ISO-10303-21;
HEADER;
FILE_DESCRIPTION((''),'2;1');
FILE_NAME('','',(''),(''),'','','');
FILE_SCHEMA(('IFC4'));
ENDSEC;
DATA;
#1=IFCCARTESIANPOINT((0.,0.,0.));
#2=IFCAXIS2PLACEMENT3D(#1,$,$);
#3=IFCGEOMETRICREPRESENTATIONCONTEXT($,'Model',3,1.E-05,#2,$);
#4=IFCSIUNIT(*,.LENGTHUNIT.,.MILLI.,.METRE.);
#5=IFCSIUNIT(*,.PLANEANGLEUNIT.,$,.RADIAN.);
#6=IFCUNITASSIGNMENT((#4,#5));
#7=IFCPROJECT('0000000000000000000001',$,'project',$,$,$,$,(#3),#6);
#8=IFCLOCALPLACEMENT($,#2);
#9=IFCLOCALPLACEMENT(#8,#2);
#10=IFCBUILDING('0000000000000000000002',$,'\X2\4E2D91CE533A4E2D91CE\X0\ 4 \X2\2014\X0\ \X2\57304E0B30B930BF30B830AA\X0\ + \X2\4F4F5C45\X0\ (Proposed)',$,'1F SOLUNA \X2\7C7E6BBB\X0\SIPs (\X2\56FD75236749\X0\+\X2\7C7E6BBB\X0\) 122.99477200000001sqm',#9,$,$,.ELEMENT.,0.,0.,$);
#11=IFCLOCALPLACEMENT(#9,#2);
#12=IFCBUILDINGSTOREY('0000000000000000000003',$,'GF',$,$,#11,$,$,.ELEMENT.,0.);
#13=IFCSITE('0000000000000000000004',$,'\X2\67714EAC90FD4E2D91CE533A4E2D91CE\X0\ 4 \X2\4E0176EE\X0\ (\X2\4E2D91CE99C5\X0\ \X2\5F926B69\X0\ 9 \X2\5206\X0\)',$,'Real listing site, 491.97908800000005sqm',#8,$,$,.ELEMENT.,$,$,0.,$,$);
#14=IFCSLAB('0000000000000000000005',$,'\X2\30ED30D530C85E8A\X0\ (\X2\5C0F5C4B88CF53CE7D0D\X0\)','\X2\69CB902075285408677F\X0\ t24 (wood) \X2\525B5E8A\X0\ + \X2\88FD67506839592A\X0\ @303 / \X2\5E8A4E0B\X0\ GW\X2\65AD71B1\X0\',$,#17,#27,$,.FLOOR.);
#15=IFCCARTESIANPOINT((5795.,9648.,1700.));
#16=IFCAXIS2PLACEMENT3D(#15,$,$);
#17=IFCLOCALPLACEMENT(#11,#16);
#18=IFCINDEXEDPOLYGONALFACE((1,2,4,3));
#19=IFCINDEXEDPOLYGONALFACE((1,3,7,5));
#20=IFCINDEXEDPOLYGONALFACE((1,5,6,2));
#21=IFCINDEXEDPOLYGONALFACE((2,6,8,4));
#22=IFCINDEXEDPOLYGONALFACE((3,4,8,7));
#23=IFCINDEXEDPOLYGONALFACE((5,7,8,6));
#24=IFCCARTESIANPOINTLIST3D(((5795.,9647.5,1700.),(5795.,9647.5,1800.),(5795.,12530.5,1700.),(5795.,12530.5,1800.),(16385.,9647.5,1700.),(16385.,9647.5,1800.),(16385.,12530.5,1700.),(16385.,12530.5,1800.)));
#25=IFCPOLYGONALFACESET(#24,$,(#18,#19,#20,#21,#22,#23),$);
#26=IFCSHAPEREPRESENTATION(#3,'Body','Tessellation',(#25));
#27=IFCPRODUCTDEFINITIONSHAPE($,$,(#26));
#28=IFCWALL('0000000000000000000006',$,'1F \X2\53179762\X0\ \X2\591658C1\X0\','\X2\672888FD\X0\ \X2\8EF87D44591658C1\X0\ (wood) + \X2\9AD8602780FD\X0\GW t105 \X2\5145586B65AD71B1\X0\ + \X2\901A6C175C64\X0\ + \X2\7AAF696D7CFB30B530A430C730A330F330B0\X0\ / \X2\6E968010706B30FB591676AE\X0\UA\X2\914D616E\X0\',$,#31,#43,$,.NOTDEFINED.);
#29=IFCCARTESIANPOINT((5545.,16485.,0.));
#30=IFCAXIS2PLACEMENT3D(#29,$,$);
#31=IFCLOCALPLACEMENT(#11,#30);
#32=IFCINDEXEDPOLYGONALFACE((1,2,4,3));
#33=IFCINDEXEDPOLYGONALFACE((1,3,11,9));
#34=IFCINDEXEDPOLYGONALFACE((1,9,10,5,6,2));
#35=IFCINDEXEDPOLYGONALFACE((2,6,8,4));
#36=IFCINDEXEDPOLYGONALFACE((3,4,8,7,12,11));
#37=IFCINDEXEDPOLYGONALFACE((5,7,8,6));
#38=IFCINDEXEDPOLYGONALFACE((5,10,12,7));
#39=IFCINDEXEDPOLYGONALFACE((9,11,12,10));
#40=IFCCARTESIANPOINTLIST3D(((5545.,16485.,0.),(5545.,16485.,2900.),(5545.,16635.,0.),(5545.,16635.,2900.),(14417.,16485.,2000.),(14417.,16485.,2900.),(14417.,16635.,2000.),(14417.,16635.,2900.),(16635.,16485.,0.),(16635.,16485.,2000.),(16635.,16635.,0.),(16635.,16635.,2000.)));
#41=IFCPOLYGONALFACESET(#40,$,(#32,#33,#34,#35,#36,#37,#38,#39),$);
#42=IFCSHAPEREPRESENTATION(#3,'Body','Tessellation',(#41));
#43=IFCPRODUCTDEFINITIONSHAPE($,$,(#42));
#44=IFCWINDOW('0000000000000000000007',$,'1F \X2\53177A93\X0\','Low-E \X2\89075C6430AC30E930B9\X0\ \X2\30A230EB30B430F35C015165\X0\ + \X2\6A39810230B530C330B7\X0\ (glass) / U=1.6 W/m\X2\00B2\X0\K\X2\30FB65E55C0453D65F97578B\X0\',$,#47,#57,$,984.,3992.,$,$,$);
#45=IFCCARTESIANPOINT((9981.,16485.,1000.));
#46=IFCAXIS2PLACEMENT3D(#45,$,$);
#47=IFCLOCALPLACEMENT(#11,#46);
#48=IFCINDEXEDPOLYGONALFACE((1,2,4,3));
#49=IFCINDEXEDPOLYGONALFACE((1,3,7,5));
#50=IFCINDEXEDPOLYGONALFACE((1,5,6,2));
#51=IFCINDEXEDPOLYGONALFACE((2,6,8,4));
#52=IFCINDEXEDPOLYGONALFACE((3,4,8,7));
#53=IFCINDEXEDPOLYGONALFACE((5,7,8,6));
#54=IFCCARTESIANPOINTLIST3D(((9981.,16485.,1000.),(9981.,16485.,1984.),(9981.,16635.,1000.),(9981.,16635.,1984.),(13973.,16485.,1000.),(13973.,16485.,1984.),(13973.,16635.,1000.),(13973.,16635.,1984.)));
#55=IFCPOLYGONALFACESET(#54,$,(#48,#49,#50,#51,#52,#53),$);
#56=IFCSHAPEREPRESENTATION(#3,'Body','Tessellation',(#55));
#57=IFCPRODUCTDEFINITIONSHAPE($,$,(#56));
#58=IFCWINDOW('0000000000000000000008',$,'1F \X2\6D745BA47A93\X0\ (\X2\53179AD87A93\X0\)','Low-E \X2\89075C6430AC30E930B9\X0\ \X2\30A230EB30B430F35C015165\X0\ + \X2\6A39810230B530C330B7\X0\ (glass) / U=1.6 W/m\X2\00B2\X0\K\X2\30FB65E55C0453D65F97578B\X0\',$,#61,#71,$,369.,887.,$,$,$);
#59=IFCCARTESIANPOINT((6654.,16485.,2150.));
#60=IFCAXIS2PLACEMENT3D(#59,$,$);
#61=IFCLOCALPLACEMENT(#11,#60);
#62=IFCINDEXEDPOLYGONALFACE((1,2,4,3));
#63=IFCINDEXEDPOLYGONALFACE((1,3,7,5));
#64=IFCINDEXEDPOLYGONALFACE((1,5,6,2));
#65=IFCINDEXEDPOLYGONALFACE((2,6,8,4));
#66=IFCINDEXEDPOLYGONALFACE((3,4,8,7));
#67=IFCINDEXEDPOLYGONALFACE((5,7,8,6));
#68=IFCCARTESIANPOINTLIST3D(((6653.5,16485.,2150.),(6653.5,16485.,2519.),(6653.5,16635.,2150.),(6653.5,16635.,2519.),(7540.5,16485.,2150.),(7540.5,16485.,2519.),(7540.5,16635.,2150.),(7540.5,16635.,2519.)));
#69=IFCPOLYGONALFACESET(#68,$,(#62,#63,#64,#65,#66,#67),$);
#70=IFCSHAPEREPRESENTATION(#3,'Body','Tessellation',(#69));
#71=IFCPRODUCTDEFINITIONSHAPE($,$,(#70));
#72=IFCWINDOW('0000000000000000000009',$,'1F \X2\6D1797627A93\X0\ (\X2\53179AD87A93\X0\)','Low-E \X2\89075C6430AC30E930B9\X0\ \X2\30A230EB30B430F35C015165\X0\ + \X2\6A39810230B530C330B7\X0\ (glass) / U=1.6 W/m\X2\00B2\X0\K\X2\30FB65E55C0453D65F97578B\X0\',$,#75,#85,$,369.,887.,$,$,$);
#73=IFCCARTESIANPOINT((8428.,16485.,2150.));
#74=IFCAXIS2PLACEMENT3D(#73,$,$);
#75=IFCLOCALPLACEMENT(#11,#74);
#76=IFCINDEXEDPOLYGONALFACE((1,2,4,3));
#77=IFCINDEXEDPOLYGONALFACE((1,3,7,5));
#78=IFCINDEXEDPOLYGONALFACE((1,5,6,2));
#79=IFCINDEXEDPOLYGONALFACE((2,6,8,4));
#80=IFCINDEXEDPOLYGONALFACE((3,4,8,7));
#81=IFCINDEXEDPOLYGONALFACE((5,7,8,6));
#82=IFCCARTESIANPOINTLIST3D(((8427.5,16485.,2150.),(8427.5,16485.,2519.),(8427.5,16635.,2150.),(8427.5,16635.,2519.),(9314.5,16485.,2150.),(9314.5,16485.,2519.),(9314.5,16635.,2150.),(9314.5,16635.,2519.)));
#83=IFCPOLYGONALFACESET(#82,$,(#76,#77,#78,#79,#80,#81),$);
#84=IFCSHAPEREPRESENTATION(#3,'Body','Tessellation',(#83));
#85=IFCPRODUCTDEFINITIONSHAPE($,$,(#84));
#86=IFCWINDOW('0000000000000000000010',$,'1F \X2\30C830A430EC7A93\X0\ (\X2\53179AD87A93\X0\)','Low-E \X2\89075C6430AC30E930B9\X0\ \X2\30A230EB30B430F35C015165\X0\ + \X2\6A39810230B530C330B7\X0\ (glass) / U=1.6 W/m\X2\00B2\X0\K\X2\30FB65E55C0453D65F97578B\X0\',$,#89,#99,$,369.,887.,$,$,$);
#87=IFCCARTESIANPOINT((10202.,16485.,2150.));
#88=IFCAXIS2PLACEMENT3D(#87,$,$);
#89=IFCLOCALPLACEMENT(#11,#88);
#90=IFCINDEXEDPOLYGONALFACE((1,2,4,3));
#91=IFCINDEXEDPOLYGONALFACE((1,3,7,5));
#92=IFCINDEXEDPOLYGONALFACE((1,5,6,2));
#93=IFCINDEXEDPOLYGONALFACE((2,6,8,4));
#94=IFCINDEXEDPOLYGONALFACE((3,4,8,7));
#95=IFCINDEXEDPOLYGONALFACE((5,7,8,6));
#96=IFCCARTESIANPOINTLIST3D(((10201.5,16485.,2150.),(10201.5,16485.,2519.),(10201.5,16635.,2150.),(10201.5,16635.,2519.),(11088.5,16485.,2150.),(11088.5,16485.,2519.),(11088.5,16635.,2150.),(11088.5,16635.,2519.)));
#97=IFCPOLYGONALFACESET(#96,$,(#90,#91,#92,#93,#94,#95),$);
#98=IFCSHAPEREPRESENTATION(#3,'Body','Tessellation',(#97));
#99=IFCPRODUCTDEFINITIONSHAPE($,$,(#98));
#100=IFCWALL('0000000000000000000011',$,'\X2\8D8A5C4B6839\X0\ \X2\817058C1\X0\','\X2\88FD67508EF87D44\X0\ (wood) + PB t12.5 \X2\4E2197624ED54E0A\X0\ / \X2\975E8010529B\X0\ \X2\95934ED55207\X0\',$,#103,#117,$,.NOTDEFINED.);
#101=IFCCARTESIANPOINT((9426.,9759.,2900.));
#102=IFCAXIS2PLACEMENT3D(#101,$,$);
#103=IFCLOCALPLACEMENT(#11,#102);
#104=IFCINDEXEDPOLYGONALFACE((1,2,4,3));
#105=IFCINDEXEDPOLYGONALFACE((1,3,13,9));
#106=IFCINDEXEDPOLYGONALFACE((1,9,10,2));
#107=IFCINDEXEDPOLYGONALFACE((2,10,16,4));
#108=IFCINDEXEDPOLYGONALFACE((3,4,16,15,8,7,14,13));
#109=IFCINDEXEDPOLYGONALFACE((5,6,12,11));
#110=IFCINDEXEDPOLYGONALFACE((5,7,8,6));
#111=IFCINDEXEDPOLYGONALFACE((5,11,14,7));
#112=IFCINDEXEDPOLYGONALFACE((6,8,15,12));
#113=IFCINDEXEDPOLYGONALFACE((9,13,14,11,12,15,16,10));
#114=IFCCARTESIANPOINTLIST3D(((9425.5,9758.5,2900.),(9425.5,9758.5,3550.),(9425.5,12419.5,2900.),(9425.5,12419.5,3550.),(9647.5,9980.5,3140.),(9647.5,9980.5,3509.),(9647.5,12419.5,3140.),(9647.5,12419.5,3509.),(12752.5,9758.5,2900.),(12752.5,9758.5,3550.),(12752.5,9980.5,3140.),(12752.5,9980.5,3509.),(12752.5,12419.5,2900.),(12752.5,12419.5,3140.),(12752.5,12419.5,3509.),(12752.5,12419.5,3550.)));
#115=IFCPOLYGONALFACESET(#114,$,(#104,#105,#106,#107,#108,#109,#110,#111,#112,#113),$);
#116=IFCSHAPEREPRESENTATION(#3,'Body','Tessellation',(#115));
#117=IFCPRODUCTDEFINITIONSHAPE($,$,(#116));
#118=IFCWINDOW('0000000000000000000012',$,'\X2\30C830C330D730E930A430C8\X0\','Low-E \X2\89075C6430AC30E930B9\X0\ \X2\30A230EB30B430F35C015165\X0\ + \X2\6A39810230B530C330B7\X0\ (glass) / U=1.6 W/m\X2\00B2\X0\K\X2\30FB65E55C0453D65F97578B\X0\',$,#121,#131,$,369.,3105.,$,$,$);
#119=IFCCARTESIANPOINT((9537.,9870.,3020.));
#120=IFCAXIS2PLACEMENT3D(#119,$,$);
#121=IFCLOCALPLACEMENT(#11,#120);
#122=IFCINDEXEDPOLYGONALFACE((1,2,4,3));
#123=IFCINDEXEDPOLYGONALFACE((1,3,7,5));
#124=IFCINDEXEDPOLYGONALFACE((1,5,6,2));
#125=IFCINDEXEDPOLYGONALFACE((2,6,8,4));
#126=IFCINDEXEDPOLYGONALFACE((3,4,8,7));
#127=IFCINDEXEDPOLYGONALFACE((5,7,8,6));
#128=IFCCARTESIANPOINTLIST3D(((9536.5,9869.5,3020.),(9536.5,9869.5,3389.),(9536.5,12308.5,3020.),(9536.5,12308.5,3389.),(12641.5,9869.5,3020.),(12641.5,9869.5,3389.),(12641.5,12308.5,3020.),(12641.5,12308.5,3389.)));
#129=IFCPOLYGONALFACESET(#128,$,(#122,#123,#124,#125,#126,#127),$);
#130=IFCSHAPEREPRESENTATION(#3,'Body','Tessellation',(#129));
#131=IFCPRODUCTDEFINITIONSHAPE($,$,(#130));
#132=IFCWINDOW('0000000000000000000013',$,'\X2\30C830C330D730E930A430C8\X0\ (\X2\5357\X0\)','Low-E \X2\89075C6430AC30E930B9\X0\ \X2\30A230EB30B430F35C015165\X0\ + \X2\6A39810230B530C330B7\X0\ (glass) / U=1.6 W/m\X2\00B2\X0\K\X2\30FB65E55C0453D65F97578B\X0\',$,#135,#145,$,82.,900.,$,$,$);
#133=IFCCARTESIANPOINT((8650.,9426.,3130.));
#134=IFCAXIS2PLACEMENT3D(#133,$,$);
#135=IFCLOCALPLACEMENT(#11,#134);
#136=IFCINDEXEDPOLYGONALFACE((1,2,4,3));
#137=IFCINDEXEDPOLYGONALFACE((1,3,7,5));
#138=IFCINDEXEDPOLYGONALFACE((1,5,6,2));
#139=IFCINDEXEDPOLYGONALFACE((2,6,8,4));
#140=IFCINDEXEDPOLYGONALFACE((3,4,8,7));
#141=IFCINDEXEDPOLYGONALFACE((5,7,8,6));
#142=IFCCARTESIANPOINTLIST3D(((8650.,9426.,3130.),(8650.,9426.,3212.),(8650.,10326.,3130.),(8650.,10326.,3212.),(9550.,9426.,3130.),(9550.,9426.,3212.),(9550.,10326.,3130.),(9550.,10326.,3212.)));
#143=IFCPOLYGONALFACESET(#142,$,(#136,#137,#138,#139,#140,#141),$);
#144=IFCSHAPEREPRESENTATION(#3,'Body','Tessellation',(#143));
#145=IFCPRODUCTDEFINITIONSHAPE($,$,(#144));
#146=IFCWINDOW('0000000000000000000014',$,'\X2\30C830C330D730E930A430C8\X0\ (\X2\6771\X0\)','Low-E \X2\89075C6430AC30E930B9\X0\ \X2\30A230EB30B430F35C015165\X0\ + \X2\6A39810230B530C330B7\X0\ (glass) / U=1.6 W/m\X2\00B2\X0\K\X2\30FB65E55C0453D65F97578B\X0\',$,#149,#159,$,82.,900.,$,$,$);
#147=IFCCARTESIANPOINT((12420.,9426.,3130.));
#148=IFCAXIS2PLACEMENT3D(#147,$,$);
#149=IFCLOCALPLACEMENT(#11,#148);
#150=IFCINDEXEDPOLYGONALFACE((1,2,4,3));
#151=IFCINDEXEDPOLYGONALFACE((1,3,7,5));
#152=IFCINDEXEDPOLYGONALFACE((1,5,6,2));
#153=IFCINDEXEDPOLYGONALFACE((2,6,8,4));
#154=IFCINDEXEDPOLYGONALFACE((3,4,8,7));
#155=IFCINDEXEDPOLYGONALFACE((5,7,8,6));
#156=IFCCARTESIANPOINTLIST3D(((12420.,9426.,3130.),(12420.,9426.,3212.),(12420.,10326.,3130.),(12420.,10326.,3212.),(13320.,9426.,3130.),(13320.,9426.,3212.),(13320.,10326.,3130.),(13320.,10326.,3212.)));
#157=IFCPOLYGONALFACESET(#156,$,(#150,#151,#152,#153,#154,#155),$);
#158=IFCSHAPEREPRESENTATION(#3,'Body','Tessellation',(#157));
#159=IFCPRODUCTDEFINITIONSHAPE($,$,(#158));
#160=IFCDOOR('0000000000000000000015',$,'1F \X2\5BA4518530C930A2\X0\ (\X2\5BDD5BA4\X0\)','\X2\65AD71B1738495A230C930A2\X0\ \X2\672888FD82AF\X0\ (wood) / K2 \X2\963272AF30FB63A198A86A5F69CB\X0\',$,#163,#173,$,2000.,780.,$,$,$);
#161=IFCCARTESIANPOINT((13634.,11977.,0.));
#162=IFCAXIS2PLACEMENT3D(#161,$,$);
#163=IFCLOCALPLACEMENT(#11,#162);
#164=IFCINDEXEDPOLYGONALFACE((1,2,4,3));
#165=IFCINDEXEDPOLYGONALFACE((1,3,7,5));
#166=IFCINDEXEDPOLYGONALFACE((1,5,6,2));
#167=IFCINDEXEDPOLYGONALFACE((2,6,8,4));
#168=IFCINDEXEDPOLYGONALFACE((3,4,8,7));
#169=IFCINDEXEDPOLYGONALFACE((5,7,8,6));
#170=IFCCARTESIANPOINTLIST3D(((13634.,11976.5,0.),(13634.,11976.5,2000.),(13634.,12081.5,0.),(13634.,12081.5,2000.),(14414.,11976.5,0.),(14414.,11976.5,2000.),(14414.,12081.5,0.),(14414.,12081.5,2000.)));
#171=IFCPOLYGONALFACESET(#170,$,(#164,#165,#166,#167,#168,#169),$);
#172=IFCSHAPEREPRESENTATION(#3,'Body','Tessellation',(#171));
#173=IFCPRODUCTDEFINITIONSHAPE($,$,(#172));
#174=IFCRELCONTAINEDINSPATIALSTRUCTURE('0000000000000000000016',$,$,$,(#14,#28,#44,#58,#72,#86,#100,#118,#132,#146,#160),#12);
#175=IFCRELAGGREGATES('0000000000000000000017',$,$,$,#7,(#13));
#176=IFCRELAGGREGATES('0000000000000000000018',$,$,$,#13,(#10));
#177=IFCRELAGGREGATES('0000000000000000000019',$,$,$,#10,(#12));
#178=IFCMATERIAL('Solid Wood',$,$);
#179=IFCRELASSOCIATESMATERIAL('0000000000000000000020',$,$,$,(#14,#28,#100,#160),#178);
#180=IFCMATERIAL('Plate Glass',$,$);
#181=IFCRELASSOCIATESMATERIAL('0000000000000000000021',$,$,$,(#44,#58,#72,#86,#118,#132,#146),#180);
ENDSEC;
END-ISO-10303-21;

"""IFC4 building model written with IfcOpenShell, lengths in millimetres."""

from ifc_helpers import new_model, si_unit, frame, frame_2d, origin, place, context, project, spatial, rectangle, extrude, material, element, fill, save


model = new_model("IFC4")

# Units and contexts
model_context = context("Model", 3, precision=1e-05, world=origin())
ifc_project = project(units=[si_unit("LENGTHUNIT", "METRE", prefix="MILLI"), si_unit("PLANEANGLEUNIT", "RADIAN")], contexts=[model_context])

# Site, building, storey
site_placement = place(None, origin())
site = spatial("IfcSite", under=ifc_project, at=site_placement, Name="東京都中野区中野 4 丁目 (中野駅 徒歩 9 分)", ObjectType="Real listing site, 491.97908800000005sqm", CompositionType="ELEMENT", RefElevation=0.0)
building_placement = place(site_placement, origin())
building = spatial("IfcBuilding", under=site, at=building_placement, Name="中野区中野 4 — 地下スタジオ + 住居 (Proposed)", ObjectType="1F SOLUNA 籾殻SIPs (国産杉+籾殻) 122.99477200000001sqm", CompositionType="ELEMENT", ElevationOfRefHeight=0.0, ElevationOfTerrain=0.0)
storey_placement = place(building_placement, origin())
storey = spatial("IfcBuildingStorey", under=building, at=storey_placement, Name="GF", CompositionType="ELEMENT", Elevation=0.0)

# Slab
ifc_material_1 = material(Name="Solid Wood")
slab_placement = place(storey_placement, frame((5795.0, 9648.0, 1700.0)))
element("IfcSlab", 1, at=slab_placement, inside=storey, material=ifc_material_1, Name="ロフト床 (小屋裏収納)", Description="構造用合板 t24 (wood) 剛床 + 製材根太 @303 / 床下 GW断熱", PredefinedType="FLOOR", context=model_context, shape_type="SweptSolid", body=[
    extrude(rectangle(XDim=10590.0, YDim=2883.0, at=frame_2d((5295.0, 1441.0))), frame((5795.0, 9648.0, 1700.0)), (0.0, 0.0, 1.0), 100.0),
])

# Wall, openings, windows
wall_1_placement = place(storey_placement, frame((5545.0, 16485.0, 0.0)))
wall_1 = element("IfcWall", 2, at=wall_1_placement, inside=storey, material=ifc_material_1, Name="1F 北面 外壁", Description="木製 軸組外壁 (wood) + 高性能GW t105 充填断熱 + 通気層 + 窯業系サイディング / 準耐火・外皮UA配慮", PredefinedType="NOTDEFINED", context=model_context, shape_type="SweptSolid", body=[
    extrude(rectangle(XDim=11090.0, YDim=150.0, at=frame_2d((5545.0, 75.0))), frame((5545.0, 16485.0, 0.0)), (0.0, 0.0, 1.0), 2900.0),
])
opening_1_placement = place(storey_placement, frame((9981.0, 16485.0, 1000.0)))
opening_1 = element("IfcOpeningElement", 3, at=opening_1_placement, cuts=wall_1, PredefinedType="NOTDEFINED", context=model_context, shape_type="SweptSolid", body=[
    extrude(rectangle(XDim=3992.0, YDim=150.0, at=frame_2d((1996.0, 75.0))), frame((9981.0, 16485.0, 1000.0)), (0.0, 0.0, 1.0), 984.0),
])
opening_2_placement = place(storey_placement, frame((6654.0, 16485.0, 2150.0)))
opening_2 = element("IfcOpeningElement", 4, at=opening_2_placement, cuts=wall_1, PredefinedType="NOTDEFINED", context=model_context, shape_type="SweptSolid", body=[
    extrude(rectangle(XDim=887.0, YDim=150.0, at=frame_2d((443.0, 75.0))), frame((6654.0, 16485.0, 2150.0)), (0.0, 0.0, 1.0), 369.0),
])
opening_3_placement = place(storey_placement, frame((8428.0, 16485.0, 2150.0)))
opening_3 = element("IfcOpeningElement", 5, at=opening_3_placement, cuts=wall_1, PredefinedType="NOTDEFINED", context=model_context, shape_type="SweptSolid", body=[
    extrude(rectangle(XDim=887.0, YDim=150.0, at=frame_2d((443.0, 75.0))), frame((8428.0, 16485.0, 2150.0)), (0.0, 0.0, 1.0), 369.0),
])
opening_4_placement = place(storey_placement, frame((10202.0, 16485.0, 2150.0)))
opening_4 = element("IfcOpeningElement", 6, at=opening_4_placement, cuts=wall_1, PredefinedType="NOTDEFINED", context=model_context, shape_type="SweptSolid", body=[
    extrude(rectangle(XDim=887.0, YDim=150.0, at=frame_2d((443.0, 75.0))), frame((10202.0, 16485.0, 2150.0)), (0.0, 0.0, 1.0), 369.0),
])
ifc_material_2 = material(Name="Plate Glass")
window_1_placement = place(storey_placement, frame((9981.0, 16485.0, 1000.0)))
window_1 = element("IfcWindow", 7, at=window_1_placement, inside=storey, material=ifc_material_2, Name="1F 北窓", Description="Low-E 複層ガラス アルゴン封入 + 樹脂サッシ (glass) / U=1.6 W/m²K・日射取得型", OverallHeight=984.0, OverallWidth=3992.0, context=model_context, shape_type="SweptSolid", body=[
    extrude(rectangle(XDim=3992.0, YDim=150.0, at=frame_2d((1996.0, 75.0))), frame((9981.0, 16485.0, 1000.0)), (0.0, 0.0, 1.0), 984.0),
])
fill(opening_1, window_1)
window_2_placement = place(storey_placement, frame((6654.0, 16485.0, 2150.0)))
window_2 = element("IfcWindow", 8, at=window_2_placement, inside=storey, material=ifc_material_2, Name="1F 浴室窓 (北高窓)", Description="Low-E 複層ガラス アルゴン封入 + 樹脂サッシ (glass) / U=1.6 W/m²K・日射取得型", OverallHeight=369.0, OverallWidth=887.0, context=model_context, shape_type="SweptSolid", body=[
    extrude(rectangle(XDim=887.0, YDim=150.0, at=frame_2d((443.0, 75.0))), frame((6654.0, 16485.0, 2150.0)), (0.0, 0.0, 1.0), 369.0),
])
fill(opening_2, window_2)
window_3_placement = place(storey_placement, frame((8428.0, 16485.0, 2150.0)))
window_3 = element("IfcWindow", 9, at=window_3_placement, inside=storey, material=ifc_material_2, Name="1F 洗面窓 (北高窓)", Description="Low-E 複層ガラス アルゴン封入 + 樹脂サッシ (glass) / U=1.6 W/m²K・日射取得型", OverallHeight=369.0, OverallWidth=887.0, context=model_context, shape_type="SweptSolid", body=[
    extrude(rectangle(XDim=887.0, YDim=150.0, at=frame_2d((443.0, 75.0))), frame((8428.0, 16485.0, 2150.0)), (0.0, 0.0, 1.0), 369.0),
])
fill(opening_3, window_3)
window_4_placement = place(storey_placement, frame((10202.0, 16485.0, 2150.0)))
window_4 = element("IfcWindow", 10, at=window_4_placement, inside=storey, material=ifc_material_2, Name="1F トイレ窓 (北高窓)", Description="Low-E 複層ガラス アルゴン封入 + 樹脂サッシ (glass) / U=1.6 W/m²K・日射取得型", OverallHeight=369.0, OverallWidth=887.0, context=model_context, shape_type="SweptSolid", body=[
    extrude(rectangle(XDim=887.0, YDim=150.0, at=frame_2d((443.0, 75.0))), frame((10202.0, 16485.0, 2150.0)), (0.0, 0.0, 1.0), 369.0),
])
fill(opening_4, window_4)

# Wall, openings, windows
wall_2_placement = place(storey_placement, frame((9426.0, 9759.0, 2900.0)))
wall_2 = element("IfcWall", 11, at=wall_2_placement, inside=storey, material=ifc_material_1, Name="越屋根 腰壁", Description="製材軸組 (wood) + PB t12.5 両面仕上 / 非耐力 間仕切", PredefinedType="NOTDEFINED", context=model_context, shape_type="SweptSolid", body=[
    extrude(rectangle(XDim=3327.0, YDim=2661.0, at=frame_2d((1663.0, 1330.0))), frame((9426.0, 9759.0, 2900.0)), (0.0, 0.0, 1.0), 650.0),
])
opening_5_placement = place(storey_placement, frame((9537.0, 9870.0, 3020.0)))
opening_5 = element("IfcOpeningElement", 12, at=opening_5_placement, cuts=wall_2, PredefinedType="NOTDEFINED", context=model_context, shape_type="SweptSolid", body=[
    extrude(rectangle(XDim=3105.0, YDim=2439.0, at=frame_2d((1552.0, 1219.0))), frame((9537.0, 9870.0, 3020.0)), (0.0, 0.0, 1.0), 369.0),
])
opening_6_placement = place(storey_placement, frame((8650.0, 9426.0, 3130.0)))
opening_6 = element("IfcOpeningElement", 13, at=opening_6_placement, cuts=wall_2, PredefinedType="NOTDEFINED", context=model_context, shape_type="SweptSolid", body=[
    extrude(rectangle(XDim=900.0, YDim=900.0, at=frame_2d((450.0, 450.0))), frame((8650.0, 9426.0, 3130.0)), (0.0, 0.0, 1.0), 82.0),
])
opening_7_placement = place(storey_placement, frame((12420.0, 9426.0, 3130.0)))
opening_7 = element("IfcOpeningElement", 14, at=opening_7_placement, cuts=wall_2, PredefinedType="NOTDEFINED", context=model_context, shape_type="SweptSolid", body=[
    extrude(rectangle(XDim=900.0, YDim=900.0, at=frame_2d((450.0, 450.0))), frame((12420.0, 9426.0, 3130.0)), (0.0, 0.0, 1.0), 82.0),
])
window_5_placement = place(storey_placement, frame((9537.0, 9870.0, 3020.0)))
window_5 = element("IfcWindow", 15, at=window_5_placement, inside=storey, material=ifc_material_2, Name="トップライト", Description="Low-E 複層ガラス アルゴン封入 + 樹脂サッシ (glass) / U=1.6 W/m²K・日射取得型", OverallHeight=369.0, OverallWidth=3105.0, context=model_context, shape_type="SweptSolid", body=[
    extrude(rectangle(XDim=3105.0, YDim=2439.0, at=frame_2d((1552.0, 1219.0))), frame((9537.0, 9870.0, 3020.0)), (0.0, 0.0, 1.0), 369.0),
])
fill(opening_5, window_5)
window_6_placement = place(storey_placement, frame((8650.0, 9426.0, 3130.0)))
window_6 = element("IfcWindow", 16, at=window_6_placement, inside=storey, material=ifc_material_2, Name="トップライト (南)", Description="Low-E 複層ガラス アルゴン封入 + 樹脂サッシ (glass) / U=1.6 W/m²K・日射取得型", OverallHeight=82.0, OverallWidth=900.0, context=model_context, shape_type="SweptSolid", body=[
    extrude(rectangle(XDim=900.0, YDim=900.0, at=frame_2d((450.0, 450.0))), frame((8650.0, 9426.0, 3130.0)), (0.0, 0.0, 1.0), 82.0),
])
fill(opening_6, window_6)
window_7_placement = place(storey_placement, frame((12420.0, 9426.0, 3130.0)))
window_7 = element("IfcWindow", 17, at=window_7_placement, inside=storey, material=ifc_material_2, Name="トップライト (東)", Description="Low-E 複層ガラス アルゴン封入 + 樹脂サッシ (glass) / U=1.6 W/m²K・日射取得型", OverallHeight=82.0, OverallWidth=900.0, context=model_context, shape_type="SweptSolid", body=[
    extrude(rectangle(XDim=900.0, YDim=900.0, at=frame_2d((450.0, 450.0))), frame((12420.0, 9426.0, 3130.0)), (0.0, 0.0, 1.0), 82.0),
])
fill(opening_7, window_7)

# Door
door_1_placement = place(storey_placement, frame((13634.0, 11977.0, 0.0)))
element("IfcDoor", 18, at=door_1_placement, inside=storey, material=ifc_material_1, Name="1F 室内ドア (寝室)", Description="断熱玄関ドア 木製芯 (wood) / K2 防犯・採風機構", OverallHeight=2000.0, OverallWidth=780.0, context=model_context, shape_type="SweptSolid", body=[
    extrude(rectangle(XDim=780.0, YDim=105.0, at=frame_2d((390.0, 52.0))), frame((13634.0, 11977.0, 0.0)), (0.0, 0.0, 1.0), 2000.0),
])

save(model, "model.ifc")
